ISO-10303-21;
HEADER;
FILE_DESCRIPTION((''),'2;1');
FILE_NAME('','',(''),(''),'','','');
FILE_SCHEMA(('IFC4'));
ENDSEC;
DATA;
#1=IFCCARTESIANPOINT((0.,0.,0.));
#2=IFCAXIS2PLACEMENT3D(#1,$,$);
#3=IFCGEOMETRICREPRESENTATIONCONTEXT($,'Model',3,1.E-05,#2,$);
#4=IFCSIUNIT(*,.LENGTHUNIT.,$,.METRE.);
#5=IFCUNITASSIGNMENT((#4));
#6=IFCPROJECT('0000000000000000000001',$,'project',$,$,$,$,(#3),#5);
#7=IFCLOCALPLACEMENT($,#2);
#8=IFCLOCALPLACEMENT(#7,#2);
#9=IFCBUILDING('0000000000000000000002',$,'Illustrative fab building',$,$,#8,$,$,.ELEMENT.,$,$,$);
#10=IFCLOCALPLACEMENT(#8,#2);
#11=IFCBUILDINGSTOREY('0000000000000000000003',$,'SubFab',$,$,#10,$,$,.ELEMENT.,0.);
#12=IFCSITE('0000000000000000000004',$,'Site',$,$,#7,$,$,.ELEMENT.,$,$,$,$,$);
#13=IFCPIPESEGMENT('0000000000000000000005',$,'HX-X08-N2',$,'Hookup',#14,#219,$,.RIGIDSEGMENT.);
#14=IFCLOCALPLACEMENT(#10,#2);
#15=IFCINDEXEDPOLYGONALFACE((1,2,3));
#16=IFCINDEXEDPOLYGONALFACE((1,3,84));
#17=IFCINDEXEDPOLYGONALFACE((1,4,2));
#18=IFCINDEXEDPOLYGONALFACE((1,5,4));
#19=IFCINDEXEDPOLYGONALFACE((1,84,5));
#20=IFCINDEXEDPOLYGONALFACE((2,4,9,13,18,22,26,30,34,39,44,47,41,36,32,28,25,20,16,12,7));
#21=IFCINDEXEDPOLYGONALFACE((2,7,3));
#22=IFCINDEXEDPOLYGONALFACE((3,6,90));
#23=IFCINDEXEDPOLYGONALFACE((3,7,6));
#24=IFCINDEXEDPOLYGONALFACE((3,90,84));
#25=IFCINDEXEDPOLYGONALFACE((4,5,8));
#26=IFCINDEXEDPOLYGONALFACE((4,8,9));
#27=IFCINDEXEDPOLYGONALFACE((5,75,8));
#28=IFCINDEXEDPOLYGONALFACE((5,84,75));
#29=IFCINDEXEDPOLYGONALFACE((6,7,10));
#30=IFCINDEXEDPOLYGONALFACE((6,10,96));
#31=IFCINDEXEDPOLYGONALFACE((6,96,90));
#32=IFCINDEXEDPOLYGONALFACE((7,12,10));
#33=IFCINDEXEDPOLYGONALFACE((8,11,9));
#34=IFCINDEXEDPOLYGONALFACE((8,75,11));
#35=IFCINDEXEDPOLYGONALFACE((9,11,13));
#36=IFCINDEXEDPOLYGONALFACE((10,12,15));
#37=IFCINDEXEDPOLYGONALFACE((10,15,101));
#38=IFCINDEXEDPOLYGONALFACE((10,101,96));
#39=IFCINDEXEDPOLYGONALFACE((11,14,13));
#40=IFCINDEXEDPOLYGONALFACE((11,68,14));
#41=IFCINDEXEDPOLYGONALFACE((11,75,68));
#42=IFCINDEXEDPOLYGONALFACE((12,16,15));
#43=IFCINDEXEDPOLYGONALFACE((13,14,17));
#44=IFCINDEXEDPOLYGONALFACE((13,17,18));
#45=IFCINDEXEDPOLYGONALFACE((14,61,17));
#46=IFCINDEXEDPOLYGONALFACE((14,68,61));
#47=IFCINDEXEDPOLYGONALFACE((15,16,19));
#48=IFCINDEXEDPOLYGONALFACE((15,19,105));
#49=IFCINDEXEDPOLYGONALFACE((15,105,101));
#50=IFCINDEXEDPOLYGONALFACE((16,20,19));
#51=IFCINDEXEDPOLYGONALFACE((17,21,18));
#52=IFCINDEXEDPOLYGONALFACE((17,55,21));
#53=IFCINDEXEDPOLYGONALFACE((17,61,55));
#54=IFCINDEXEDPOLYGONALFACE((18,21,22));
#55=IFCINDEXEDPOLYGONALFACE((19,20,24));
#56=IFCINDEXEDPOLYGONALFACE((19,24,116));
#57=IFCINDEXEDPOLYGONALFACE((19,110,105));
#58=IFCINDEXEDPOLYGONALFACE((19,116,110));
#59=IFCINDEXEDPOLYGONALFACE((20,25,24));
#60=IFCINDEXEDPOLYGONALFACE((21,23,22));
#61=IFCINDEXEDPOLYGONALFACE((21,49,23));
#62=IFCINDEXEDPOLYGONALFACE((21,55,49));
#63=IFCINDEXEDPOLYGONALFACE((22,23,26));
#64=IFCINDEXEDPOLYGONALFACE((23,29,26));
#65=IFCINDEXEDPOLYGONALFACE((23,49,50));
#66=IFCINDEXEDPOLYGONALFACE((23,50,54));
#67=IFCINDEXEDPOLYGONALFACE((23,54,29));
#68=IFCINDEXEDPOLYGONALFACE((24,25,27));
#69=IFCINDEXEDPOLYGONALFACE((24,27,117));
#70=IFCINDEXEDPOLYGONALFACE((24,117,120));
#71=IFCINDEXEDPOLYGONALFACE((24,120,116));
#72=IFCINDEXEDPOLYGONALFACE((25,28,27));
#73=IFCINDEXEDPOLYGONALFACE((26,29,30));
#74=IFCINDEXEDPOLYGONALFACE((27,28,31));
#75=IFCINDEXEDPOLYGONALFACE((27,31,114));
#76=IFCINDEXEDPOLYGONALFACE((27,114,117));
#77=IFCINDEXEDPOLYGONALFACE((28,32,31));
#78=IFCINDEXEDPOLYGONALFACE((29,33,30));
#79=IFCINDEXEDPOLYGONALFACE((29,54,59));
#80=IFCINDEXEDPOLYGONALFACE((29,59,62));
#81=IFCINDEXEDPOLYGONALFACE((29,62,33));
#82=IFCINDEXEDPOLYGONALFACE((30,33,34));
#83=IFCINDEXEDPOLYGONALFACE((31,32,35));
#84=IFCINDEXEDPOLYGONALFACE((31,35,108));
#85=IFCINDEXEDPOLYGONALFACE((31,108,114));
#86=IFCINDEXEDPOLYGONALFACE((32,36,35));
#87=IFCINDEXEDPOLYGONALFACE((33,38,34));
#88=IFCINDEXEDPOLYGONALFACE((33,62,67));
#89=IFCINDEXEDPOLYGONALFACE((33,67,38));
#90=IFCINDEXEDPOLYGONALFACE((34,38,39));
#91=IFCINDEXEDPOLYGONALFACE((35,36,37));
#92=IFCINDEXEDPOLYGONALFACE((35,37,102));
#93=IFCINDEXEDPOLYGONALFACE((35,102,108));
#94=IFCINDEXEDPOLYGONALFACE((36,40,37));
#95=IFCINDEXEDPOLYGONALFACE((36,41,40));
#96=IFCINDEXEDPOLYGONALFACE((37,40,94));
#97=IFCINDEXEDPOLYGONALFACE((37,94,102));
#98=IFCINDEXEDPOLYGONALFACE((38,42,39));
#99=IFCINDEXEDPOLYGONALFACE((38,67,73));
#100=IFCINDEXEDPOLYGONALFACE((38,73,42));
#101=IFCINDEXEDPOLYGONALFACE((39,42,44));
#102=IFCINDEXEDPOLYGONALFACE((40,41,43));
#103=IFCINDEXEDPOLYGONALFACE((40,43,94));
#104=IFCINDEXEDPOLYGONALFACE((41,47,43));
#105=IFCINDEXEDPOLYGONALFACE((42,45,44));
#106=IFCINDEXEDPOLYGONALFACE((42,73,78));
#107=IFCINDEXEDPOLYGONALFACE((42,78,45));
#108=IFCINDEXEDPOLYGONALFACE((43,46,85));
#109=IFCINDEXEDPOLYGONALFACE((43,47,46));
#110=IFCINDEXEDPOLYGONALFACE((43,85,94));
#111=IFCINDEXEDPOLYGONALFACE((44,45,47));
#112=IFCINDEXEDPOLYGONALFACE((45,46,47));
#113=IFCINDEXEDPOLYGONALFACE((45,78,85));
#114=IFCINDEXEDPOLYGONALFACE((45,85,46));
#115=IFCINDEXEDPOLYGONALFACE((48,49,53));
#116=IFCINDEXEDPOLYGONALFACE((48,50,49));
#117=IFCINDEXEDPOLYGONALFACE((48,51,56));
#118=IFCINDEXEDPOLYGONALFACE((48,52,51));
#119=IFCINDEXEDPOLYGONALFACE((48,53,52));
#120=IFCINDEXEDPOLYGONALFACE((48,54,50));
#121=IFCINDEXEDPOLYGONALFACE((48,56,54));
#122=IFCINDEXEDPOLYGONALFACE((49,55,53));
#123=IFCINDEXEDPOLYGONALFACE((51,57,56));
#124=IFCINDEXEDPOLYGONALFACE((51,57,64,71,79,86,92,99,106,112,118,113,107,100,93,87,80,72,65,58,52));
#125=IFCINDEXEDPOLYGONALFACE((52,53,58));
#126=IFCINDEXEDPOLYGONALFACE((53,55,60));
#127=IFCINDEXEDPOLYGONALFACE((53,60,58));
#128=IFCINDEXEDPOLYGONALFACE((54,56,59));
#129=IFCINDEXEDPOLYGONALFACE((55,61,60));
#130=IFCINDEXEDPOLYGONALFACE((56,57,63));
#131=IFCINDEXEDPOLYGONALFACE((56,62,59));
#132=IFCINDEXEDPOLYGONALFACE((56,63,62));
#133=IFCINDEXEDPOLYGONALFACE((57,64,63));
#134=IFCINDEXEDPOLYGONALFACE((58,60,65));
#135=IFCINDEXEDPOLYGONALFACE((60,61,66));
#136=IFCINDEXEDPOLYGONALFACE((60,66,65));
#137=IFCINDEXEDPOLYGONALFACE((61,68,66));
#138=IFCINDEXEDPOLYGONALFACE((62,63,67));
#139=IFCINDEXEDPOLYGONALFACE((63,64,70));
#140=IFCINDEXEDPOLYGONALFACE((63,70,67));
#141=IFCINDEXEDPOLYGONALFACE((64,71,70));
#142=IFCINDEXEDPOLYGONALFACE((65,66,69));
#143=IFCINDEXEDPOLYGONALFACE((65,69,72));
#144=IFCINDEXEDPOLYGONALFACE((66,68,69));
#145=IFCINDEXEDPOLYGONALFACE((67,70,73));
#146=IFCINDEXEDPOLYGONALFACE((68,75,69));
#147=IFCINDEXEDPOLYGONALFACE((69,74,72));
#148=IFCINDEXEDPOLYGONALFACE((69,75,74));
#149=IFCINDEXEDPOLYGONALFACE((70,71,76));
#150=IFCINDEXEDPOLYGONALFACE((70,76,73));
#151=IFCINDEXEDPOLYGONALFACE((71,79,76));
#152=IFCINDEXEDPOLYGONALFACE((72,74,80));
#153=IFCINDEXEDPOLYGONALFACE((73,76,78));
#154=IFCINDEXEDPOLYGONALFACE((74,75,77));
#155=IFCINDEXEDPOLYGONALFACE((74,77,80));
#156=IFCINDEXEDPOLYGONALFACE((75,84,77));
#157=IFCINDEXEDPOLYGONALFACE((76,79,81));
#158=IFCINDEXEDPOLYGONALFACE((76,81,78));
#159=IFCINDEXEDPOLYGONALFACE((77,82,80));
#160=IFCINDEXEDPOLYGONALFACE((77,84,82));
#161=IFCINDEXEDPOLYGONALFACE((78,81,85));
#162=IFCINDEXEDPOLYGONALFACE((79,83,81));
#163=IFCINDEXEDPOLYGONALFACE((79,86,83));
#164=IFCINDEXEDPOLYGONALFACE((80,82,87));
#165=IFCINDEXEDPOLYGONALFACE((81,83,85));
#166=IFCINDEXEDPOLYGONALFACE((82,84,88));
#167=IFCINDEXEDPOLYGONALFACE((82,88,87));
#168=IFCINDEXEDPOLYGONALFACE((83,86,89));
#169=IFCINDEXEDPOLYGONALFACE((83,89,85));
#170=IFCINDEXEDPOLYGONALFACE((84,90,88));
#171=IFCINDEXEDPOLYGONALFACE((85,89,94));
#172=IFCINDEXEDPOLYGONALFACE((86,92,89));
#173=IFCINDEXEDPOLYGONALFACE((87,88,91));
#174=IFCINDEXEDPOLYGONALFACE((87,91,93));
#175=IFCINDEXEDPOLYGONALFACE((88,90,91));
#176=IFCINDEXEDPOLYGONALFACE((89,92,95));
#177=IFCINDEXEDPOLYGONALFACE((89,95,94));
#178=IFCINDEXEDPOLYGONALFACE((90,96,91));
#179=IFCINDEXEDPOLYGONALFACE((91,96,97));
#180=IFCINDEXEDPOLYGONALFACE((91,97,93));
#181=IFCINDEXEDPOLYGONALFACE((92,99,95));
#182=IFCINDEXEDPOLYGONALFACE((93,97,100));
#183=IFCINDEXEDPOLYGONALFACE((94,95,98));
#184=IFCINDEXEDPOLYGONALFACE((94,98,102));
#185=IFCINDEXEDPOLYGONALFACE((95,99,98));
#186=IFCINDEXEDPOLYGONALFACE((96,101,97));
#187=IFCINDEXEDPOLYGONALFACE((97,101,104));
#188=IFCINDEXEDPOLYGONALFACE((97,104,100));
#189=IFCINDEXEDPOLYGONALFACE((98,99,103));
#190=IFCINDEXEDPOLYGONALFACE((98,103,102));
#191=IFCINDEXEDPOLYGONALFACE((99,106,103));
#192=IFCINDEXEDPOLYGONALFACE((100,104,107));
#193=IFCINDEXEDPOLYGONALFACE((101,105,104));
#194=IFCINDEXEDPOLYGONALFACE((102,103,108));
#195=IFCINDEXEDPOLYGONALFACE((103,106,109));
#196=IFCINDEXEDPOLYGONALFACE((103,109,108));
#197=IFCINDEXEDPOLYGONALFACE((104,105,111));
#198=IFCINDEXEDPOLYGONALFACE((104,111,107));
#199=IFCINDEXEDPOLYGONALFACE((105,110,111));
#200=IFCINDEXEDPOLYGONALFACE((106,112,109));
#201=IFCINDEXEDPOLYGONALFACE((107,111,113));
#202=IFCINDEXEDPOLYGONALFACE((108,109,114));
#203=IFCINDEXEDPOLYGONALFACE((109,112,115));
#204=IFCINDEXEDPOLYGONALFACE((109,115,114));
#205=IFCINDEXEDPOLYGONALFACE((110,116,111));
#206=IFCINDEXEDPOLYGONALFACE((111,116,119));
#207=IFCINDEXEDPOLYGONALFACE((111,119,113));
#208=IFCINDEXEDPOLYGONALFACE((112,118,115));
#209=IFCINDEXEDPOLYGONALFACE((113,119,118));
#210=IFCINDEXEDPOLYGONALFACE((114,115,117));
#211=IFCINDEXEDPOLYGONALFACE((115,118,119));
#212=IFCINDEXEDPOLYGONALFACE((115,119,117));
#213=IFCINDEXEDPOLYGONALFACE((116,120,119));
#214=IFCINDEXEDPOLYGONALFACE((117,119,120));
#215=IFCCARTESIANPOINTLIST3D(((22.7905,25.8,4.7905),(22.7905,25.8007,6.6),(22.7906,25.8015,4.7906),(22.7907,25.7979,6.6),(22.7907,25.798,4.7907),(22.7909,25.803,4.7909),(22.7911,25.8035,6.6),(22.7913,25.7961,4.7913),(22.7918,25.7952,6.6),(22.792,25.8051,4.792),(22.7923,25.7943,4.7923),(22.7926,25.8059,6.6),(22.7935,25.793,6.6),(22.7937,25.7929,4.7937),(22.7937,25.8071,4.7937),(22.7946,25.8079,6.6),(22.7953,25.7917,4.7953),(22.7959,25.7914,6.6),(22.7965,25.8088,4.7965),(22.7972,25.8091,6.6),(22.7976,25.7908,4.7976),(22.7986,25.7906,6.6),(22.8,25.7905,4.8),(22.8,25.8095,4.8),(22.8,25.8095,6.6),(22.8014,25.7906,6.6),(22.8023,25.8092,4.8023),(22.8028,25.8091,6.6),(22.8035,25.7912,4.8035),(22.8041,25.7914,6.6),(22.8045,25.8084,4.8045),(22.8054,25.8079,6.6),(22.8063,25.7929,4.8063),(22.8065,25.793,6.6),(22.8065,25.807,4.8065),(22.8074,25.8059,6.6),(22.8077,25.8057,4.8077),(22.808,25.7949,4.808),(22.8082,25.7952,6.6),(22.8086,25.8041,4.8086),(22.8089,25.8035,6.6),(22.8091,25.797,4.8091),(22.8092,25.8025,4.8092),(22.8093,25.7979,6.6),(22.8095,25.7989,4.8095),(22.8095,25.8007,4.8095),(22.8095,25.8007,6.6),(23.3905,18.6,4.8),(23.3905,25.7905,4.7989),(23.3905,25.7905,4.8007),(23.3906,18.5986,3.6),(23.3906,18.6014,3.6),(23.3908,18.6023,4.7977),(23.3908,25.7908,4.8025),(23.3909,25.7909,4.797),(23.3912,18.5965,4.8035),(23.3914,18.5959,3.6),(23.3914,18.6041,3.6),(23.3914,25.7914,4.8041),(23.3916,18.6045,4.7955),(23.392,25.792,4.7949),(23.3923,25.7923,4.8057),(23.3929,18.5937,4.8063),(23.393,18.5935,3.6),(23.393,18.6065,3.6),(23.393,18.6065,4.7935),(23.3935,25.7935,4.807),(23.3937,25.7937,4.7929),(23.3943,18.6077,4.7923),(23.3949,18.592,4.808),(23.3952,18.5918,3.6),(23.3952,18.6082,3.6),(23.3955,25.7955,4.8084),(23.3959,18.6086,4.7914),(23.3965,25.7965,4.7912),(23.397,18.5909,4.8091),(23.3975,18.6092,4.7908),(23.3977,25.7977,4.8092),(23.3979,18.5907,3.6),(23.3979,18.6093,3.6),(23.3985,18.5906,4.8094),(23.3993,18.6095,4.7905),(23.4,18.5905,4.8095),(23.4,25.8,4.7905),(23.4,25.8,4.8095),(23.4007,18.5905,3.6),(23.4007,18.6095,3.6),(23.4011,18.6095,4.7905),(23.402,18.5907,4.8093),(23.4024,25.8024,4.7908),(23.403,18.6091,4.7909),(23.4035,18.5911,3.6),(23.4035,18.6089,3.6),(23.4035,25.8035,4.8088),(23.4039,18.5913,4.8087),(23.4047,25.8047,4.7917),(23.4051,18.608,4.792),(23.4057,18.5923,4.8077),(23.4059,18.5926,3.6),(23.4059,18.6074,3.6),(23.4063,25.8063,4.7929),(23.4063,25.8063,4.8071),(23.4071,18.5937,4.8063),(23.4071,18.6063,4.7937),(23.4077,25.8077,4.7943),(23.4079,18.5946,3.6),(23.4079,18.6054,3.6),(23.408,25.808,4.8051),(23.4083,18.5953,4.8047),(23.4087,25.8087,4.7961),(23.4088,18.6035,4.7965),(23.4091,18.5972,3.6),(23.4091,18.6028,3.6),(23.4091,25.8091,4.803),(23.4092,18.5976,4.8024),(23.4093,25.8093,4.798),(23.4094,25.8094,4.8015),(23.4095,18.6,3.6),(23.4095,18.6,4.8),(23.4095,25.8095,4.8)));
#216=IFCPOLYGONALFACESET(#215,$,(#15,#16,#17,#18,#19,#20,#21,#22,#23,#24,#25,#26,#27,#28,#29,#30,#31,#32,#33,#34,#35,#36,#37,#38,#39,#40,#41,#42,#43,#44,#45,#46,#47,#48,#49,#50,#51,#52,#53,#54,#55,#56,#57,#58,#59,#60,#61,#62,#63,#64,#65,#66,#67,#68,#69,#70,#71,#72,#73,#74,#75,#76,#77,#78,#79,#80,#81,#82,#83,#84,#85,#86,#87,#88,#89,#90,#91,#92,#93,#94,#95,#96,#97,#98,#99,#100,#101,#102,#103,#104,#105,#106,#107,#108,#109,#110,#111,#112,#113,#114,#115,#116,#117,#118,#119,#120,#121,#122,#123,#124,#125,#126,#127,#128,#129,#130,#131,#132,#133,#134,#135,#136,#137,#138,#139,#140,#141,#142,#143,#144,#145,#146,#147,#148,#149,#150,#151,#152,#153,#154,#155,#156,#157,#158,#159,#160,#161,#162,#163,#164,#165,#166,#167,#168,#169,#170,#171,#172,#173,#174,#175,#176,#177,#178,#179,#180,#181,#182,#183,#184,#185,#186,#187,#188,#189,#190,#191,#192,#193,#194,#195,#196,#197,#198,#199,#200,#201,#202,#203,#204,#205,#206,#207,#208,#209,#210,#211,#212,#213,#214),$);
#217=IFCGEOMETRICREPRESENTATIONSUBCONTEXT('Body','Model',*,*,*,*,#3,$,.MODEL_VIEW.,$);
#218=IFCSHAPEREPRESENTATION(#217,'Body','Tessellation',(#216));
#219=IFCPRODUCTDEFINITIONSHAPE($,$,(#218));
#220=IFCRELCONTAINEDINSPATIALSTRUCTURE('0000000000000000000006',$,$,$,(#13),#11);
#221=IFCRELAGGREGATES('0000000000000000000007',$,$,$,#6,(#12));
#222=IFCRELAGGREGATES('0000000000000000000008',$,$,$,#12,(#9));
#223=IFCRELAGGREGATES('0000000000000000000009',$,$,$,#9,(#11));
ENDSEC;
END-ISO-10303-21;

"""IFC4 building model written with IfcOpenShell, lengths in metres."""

from ifc_helpers import new_model, entity, si_unit, origin, place, context, subcontext, project, spatial, element, save


model = new_model("IFC4")

# Units and contexts
model_context = context("Model", 3, precision=1e-05, world=origin())
body_context = subcontext(model_context, "Body", "Model", "MODEL_VIEW")
ifc_project = project(units=[si_unit("LENGTHUNIT", "METRE")], contexts=[model_context])

# Site, building, storey
site_placement = place(None, origin())
site = spatial("IfcSite", under=ifc_project, at=site_placement, Name="Site", CompositionType="ELEMENT")
building_placement = place(site_placement, origin())
building = spatial("IfcBuilding", under=site, at=building_placement, Name="Illustrative fab building", CompositionType="ELEMENT")
storey_placement = place(building_placement, origin())
storey = spatial("IfcBuildingStorey", under=building, at=storey_placement, Name="SubFab", CompositionType="ELEMENT", Elevation=0.0)

# Pipe segment
pipe_segment_1_placement = place(storey_placement, origin())
element("IfcPipeSegment", 1, at=pipe_segment_1_placement, inside=storey, Name="HX-X08-N2", ObjectType="Hookup", PredefinedType="RIGIDSEGMENT", context=body_context, shape_type="AdvancedSweptSolid", body=[
    entity("IfcSweptDiskSolid", entity("IfcPolyline", [entity("IfcCartesianPoint", [23.4, 18.6, 3.6]), entity("IfcCartesianPoint", [23.4, 18.6, 4.8]), entity("IfcCartesianPoint", [23.4, 25.8, 4.8]), entity("IfcCartesianPoint", [22.8, 25.8, 4.8]), entity("IfcCartesianPoint", [22.8, 25.8, 6.6])]), 0.0095),
])

save(model, "model.ifc")
